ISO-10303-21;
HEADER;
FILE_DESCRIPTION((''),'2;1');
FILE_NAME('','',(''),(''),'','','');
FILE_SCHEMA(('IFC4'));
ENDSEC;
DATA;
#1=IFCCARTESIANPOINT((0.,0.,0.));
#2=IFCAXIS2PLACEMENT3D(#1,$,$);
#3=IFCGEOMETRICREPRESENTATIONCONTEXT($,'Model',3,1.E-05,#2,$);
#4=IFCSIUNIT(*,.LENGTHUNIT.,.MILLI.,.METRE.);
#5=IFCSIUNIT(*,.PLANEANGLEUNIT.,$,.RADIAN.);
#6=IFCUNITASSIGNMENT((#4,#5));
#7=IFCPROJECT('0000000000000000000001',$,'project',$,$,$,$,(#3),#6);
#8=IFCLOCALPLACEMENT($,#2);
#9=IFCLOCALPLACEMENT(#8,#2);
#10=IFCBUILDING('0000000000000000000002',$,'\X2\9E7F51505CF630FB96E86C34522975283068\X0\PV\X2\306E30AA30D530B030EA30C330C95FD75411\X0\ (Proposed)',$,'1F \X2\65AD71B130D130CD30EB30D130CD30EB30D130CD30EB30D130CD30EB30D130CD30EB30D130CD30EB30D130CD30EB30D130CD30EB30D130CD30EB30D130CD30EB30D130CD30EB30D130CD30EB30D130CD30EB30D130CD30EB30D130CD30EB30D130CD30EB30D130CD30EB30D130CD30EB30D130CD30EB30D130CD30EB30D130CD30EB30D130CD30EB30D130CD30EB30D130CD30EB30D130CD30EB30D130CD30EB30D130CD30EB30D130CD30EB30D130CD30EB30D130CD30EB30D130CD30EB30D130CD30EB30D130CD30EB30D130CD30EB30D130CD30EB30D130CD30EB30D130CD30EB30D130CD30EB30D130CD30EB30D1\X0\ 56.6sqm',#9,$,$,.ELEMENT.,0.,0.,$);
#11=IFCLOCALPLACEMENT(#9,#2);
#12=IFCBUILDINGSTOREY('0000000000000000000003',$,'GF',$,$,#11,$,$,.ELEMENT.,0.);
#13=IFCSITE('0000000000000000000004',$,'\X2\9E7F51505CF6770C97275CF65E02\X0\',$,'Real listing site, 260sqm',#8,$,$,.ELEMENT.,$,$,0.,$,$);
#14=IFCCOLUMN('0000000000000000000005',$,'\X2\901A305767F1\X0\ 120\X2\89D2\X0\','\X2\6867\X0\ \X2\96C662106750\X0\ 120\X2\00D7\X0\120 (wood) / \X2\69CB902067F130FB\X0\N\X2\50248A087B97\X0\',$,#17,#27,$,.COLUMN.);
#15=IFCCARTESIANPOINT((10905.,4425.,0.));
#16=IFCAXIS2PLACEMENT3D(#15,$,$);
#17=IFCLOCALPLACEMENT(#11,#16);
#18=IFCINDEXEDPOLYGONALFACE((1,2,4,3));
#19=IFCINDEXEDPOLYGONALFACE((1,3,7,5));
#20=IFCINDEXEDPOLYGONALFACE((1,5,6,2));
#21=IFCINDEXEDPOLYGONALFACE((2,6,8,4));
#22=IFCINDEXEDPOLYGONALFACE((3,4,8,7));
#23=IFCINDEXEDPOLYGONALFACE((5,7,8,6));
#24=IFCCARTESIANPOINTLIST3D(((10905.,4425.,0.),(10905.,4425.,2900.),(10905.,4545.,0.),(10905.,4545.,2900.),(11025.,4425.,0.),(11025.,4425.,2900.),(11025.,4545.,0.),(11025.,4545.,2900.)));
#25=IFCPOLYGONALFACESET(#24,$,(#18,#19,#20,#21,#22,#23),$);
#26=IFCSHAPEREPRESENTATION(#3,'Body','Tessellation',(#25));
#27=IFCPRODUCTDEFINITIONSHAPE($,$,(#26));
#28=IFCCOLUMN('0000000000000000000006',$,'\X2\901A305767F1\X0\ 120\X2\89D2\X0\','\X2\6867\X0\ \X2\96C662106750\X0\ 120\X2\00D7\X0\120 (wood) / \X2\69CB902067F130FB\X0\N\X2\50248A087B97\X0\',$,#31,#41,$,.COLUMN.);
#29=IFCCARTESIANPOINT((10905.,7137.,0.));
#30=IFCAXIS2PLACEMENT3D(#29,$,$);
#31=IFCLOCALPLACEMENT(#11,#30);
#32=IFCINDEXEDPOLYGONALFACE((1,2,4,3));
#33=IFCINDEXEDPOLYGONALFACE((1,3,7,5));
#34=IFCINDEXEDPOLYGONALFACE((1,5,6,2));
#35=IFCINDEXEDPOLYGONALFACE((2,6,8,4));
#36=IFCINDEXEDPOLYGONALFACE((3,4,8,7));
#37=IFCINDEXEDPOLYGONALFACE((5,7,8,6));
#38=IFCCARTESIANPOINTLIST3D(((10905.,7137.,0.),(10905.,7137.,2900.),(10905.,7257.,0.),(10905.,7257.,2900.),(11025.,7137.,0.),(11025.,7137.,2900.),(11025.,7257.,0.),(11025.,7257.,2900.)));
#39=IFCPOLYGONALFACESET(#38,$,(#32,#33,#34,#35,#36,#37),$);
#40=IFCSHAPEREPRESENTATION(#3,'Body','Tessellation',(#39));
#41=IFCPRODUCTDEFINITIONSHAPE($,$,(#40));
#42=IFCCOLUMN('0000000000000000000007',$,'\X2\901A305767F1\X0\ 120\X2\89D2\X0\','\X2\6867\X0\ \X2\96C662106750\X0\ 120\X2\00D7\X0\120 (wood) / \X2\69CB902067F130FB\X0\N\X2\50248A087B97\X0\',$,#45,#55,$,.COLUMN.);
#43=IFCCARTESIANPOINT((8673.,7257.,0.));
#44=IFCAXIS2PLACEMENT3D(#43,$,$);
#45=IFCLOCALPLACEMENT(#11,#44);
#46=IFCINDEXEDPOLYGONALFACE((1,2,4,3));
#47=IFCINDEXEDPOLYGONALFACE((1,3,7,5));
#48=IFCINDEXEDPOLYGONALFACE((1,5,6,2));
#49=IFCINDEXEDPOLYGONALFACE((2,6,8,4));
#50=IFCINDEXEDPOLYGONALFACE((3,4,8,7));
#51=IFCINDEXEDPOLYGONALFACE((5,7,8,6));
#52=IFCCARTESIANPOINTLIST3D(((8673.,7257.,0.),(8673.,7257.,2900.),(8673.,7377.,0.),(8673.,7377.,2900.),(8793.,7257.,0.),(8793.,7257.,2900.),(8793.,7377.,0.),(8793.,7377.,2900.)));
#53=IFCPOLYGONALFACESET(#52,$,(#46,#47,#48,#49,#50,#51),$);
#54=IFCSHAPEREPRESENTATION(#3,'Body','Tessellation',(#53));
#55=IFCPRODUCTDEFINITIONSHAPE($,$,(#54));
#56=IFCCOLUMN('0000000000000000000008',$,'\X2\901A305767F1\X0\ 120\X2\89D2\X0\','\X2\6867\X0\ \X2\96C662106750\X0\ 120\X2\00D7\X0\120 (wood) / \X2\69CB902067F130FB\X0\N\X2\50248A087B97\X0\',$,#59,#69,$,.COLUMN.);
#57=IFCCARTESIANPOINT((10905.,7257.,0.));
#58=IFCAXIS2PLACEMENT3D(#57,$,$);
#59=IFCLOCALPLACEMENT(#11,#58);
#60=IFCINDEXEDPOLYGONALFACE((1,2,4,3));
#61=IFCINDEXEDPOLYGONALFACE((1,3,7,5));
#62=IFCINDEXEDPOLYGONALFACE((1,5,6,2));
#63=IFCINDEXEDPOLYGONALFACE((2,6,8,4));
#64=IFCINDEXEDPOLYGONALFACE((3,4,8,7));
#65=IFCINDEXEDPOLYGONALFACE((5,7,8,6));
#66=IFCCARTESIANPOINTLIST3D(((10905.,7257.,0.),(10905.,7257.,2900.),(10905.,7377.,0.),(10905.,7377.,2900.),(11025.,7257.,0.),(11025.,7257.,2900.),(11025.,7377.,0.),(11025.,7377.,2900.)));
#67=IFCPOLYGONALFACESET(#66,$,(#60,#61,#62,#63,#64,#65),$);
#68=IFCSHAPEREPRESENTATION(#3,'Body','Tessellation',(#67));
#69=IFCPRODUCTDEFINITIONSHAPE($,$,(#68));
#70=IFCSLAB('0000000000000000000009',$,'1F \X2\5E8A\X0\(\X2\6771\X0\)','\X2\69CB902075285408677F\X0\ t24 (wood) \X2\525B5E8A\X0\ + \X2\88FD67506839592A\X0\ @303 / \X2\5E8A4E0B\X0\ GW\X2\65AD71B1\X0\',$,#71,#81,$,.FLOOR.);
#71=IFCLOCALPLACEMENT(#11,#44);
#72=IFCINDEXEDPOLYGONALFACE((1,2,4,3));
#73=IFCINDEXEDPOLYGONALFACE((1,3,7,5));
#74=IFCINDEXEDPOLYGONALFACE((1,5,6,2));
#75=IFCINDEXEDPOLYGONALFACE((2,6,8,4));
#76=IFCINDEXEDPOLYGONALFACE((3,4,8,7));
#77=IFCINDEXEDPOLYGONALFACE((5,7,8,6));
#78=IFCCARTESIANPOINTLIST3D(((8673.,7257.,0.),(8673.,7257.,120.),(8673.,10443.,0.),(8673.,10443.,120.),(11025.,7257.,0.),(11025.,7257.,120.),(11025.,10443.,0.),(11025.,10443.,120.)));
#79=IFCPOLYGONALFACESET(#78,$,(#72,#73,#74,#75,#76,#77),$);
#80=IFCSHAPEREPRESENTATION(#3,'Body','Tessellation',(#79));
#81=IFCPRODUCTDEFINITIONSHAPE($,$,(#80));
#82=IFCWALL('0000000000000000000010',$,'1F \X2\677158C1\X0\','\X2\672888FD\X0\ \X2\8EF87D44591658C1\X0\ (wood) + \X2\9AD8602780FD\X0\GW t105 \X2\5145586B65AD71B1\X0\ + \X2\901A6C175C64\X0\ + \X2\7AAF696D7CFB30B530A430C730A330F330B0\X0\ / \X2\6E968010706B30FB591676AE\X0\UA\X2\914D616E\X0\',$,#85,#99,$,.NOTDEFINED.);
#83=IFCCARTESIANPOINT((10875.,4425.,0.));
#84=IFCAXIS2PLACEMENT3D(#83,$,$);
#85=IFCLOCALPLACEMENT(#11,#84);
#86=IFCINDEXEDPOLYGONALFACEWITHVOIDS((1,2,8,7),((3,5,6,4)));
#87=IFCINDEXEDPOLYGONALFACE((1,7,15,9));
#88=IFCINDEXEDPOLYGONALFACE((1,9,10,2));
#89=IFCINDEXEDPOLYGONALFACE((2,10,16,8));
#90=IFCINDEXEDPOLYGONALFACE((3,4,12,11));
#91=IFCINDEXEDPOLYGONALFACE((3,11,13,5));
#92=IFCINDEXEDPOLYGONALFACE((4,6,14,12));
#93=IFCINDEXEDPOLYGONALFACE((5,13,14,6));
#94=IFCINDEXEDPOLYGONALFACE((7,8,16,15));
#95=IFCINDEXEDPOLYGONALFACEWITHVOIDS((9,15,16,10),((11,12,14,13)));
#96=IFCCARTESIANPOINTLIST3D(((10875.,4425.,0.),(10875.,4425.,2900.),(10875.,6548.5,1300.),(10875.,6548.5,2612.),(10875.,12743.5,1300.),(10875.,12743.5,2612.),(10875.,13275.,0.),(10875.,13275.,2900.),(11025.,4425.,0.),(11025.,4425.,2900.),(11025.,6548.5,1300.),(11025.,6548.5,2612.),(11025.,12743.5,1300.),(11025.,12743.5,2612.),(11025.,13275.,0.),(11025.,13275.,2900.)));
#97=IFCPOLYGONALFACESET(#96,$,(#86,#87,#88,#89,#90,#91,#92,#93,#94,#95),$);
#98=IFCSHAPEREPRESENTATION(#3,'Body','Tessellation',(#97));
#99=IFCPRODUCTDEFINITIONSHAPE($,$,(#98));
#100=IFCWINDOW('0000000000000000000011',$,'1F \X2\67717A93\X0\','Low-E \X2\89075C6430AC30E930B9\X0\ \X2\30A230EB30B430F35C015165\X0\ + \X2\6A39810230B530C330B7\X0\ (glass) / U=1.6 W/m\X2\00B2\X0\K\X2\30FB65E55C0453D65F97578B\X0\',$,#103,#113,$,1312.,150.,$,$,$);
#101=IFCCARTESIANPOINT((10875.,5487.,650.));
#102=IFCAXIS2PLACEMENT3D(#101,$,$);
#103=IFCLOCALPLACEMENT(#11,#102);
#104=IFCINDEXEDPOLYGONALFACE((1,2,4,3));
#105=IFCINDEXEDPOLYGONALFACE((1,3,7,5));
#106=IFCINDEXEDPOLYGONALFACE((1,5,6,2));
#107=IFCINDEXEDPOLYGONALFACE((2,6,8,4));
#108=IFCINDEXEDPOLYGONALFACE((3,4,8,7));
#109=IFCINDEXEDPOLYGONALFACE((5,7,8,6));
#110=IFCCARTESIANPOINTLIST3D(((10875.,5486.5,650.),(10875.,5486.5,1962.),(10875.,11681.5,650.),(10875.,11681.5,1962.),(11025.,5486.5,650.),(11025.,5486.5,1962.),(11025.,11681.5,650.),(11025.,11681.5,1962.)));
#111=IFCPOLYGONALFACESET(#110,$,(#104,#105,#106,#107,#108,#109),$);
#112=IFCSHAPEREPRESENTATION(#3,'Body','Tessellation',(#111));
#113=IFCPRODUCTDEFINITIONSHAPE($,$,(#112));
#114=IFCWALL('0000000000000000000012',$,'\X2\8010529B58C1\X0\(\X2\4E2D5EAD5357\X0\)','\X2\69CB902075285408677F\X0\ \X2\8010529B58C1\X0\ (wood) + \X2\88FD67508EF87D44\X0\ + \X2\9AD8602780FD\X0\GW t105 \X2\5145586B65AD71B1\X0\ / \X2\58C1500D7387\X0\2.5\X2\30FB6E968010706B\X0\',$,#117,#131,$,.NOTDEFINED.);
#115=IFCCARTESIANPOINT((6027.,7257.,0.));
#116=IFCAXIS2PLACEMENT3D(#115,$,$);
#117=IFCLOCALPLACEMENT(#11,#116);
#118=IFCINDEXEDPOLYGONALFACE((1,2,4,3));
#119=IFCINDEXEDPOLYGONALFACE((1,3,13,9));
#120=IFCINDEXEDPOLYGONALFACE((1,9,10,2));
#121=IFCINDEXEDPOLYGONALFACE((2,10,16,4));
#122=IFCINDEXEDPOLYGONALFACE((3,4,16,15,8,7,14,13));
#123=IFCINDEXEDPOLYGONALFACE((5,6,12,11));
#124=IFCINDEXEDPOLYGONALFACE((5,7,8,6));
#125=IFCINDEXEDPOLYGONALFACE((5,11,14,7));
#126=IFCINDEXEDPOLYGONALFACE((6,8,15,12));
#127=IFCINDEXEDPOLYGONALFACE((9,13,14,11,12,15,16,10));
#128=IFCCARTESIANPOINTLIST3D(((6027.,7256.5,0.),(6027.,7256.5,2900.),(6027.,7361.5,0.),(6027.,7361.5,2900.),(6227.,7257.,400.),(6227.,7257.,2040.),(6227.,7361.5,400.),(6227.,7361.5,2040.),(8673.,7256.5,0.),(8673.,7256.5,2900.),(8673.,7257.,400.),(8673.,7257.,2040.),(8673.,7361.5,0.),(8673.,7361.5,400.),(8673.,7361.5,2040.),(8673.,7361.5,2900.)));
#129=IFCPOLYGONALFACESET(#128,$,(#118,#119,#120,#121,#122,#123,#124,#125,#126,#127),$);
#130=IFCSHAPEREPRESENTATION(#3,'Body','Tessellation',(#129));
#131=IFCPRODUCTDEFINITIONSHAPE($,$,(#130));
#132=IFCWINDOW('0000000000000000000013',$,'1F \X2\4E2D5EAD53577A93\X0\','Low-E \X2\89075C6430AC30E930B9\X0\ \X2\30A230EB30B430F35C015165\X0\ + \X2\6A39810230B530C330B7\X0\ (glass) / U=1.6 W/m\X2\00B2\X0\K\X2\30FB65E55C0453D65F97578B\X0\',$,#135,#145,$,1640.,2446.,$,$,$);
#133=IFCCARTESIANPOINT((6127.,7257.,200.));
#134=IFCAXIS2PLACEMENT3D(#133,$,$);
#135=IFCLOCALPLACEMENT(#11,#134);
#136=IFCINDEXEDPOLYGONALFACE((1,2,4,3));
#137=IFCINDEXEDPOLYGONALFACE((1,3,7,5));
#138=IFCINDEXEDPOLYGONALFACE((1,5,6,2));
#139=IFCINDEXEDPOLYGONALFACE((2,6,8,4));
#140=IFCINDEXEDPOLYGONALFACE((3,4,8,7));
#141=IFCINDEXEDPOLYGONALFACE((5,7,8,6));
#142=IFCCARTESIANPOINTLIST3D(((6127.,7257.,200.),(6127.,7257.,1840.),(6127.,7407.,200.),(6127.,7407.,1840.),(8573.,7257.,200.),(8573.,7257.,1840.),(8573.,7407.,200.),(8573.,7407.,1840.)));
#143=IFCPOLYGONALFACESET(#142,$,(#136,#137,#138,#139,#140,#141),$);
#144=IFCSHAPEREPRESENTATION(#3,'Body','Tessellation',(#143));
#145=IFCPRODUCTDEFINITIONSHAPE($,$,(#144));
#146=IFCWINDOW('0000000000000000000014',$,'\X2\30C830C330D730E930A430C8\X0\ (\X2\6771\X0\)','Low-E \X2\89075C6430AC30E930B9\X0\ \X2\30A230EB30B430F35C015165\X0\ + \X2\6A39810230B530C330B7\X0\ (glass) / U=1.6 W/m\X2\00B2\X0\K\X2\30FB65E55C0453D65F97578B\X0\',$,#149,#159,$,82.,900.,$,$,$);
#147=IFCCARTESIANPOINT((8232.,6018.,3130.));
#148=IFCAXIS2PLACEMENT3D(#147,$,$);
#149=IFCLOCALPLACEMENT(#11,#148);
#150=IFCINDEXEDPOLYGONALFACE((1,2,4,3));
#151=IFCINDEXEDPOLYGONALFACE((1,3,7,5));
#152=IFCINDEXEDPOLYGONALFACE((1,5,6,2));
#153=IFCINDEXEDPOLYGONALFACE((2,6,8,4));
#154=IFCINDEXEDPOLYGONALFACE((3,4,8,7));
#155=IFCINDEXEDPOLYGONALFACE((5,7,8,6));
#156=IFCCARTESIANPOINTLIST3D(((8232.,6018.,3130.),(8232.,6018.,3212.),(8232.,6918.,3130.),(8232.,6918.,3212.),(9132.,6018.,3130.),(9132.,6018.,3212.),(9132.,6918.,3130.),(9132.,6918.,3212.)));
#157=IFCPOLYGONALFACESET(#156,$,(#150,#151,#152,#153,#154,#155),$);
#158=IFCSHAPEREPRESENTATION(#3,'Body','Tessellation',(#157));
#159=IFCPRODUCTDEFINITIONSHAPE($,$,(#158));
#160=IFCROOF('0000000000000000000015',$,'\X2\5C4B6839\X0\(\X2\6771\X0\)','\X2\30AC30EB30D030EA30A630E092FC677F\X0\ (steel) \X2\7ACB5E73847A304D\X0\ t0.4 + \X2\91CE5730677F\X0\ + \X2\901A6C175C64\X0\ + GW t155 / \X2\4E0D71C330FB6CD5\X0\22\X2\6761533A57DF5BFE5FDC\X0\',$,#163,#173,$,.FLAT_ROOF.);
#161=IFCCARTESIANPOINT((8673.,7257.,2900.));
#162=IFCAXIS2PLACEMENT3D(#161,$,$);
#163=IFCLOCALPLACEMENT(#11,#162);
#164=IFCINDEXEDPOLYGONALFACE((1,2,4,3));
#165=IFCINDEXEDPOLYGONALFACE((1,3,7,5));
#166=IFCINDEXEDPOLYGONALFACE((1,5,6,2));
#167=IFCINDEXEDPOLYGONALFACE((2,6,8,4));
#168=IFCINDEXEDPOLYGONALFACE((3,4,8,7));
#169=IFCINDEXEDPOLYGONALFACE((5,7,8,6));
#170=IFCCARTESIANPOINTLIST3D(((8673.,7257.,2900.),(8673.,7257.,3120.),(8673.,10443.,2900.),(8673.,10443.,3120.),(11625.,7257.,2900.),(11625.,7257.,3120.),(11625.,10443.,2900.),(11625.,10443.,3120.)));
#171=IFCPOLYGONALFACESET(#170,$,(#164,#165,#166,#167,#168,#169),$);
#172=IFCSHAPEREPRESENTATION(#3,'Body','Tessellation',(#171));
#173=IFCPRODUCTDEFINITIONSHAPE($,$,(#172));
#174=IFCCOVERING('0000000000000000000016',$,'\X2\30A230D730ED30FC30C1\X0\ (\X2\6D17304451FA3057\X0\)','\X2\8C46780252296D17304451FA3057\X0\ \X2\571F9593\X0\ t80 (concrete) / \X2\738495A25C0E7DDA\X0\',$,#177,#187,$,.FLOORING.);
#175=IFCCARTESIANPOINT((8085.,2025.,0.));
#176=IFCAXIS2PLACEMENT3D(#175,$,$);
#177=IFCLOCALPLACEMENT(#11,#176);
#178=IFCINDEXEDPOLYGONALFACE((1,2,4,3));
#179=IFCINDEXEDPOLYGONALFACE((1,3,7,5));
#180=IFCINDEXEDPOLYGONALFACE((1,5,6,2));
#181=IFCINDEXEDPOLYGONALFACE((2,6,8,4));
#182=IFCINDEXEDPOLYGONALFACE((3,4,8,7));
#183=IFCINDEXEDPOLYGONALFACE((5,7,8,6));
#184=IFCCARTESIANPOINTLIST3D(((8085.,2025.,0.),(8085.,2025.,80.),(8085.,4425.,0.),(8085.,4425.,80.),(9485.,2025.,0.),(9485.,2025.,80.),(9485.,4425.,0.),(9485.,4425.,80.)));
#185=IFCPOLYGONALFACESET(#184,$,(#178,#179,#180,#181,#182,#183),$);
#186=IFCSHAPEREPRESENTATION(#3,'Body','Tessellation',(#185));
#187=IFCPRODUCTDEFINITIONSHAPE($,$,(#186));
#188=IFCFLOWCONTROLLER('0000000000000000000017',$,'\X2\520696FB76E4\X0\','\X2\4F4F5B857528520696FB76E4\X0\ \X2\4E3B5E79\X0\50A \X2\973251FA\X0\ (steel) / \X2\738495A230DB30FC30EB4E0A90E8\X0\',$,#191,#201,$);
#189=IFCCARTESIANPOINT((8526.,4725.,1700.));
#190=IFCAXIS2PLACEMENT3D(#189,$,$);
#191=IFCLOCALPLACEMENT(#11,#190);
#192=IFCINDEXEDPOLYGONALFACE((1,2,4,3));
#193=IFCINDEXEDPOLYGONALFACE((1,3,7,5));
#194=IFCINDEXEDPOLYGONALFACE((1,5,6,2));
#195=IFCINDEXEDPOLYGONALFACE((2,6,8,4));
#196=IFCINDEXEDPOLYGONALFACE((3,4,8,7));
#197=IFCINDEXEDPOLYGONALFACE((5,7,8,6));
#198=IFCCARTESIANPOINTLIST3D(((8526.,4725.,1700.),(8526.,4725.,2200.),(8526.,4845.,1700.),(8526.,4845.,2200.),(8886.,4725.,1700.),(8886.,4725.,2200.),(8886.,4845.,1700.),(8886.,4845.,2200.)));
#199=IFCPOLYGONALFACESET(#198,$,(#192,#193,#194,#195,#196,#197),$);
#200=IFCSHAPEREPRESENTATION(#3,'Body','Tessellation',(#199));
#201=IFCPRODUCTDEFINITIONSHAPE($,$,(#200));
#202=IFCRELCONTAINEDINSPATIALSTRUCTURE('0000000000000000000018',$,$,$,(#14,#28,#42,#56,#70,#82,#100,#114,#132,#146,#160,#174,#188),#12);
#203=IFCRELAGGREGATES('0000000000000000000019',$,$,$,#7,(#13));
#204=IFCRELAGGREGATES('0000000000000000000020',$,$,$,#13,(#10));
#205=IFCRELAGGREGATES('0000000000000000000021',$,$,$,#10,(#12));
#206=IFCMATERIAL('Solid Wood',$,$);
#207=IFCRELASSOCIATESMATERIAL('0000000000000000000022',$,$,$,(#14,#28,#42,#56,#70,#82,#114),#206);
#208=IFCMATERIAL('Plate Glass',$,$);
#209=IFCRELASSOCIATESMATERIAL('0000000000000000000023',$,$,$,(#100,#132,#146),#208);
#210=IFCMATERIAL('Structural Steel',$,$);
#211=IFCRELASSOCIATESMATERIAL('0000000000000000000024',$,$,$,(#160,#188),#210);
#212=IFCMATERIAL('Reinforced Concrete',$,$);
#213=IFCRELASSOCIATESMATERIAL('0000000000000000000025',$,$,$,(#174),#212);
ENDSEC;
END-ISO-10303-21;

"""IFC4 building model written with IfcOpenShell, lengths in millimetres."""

from ifc_helpers import new_model, si_unit, frame, frame_2d, origin, place, context, project, spatial, rectangle, extrude, material, element, fill, save


model = new_model("IFC4")

# Units and contexts
model_context = context("Model", 3, precision=1e-05, world=origin())
ifc_project = project(units=[si_unit("LENGTHUNIT", "METRE", prefix="MILLI"), si_unit("PLANEANGLEUNIT", "RADIAN")], contexts=[model_context])

# Site, building, storey
site_placement = place(None, origin())
site = spatial("IfcSite", under=ifc_project, at=site_placement, Name="鹿児島県霧島市", ObjectType="Real listing site, 260sqm", CompositionType="ELEMENT", RefElevation=0.0)
building_placement = place(site_placement, origin())
building = spatial("IfcBuilding", under=site, at=building_placement, Name="鹿児島・雨水利用とPVのオフグリッド志向 (Proposed)", ObjectType="1F 断熱パネルパネルパネルパネルパネルパネルパネルパネルパネルパネルパネルパネルパネルパネルパネルパネルパネルパネルパネルパネルパネルパネルパネルパネルパネルパネルパネルパネルパネルパネルパネルパネルパネルパネルパネルパネルパネルパネルパネルパ 56.6sqm", CompositionType="ELEMENT", ElevationOfRefHeight=0.0, ElevationOfTerrain=0.0)
storey_placement = place(building_placement, origin())
storey = spatial("IfcBuildingStorey", under=building, at=storey_placement, Name="GF", CompositionType="ELEMENT", Elevation=0.0)

# Columns
ifc_material_1 = material(Name="Solid Wood")
column_1_placement = place(storey_placement, frame((10905.0, 4425.0, 0.0)))
element("IfcColumn", 1, at=column_1_placement, inside=storey, material=ifc_material_1, Name="通し柱 120角", Description="桧 集成材 120×120 (wood) / 構造柱・N値計算", PredefinedType="COLUMN", context=model_context, shape_type="SweptSolid", body=[
    extrude(rectangle(XDim=120.0, YDim=120.0, at=frame_2d((60.0, 60.0))), frame((10905.0, 4425.0, 0.0)), (0.0, 0.0, 1.0), 2900.0),
])
column_2_placement = place(storey_placement, frame((10905.0, 7137.0, 0.0)))
element("IfcColumn", 2, at=column_2_placement, inside=storey, material=ifc_material_1, Name="通し柱 120角", Description="桧 集成材 120×120 (wood) / 構造柱・N値計算", PredefinedType="COLUMN", context=model_context, shape_type="SweptSolid", body=[
    extrude(rectangle(XDim=120.0, YDim=120.0, at=frame_2d((60.0, 60.0))), frame((10905.0, 7137.0, 0.0)), (0.0, 0.0, 1.0), 2900.0),
])
column_3_placement = place(storey_placement, frame((8673.0, 7257.0, 0.0)))
element("IfcColumn", 3, at=column_3_placement, inside=storey, material=ifc_material_1, Name="通し柱 120角", Description="桧 集成材 120×120 (wood) / 構造柱・N値計算", PredefinedType="COLUMN", context=model_context, shape_type="SweptSolid", body=[
    extrude(rectangle(XDim=120.0, YDim=120.0, at=frame_2d((60.0, 60.0))), frame((8673.0, 7257.0, 0.0)), (0.0, 0.0, 1.0), 2900.0),
])
column_4_placement = place(storey_placement, frame((10905.0, 7257.0, 0.0)))
element("IfcColumn", 4, at=column_4_placement, inside=storey, material=ifc_material_1, Name="通し柱 120角", Description="桧 集成材 120×120 (wood) / 構造柱・N値計算", PredefinedType="COLUMN", context=model_context, shape_type="SweptSolid", body=[
    extrude(rectangle(XDim=120.0, YDim=120.0, at=frame_2d((60.0, 60.0))), frame((10905.0, 7257.0, 0.0)), (0.0, 0.0, 1.0), 2900.0),
])

# Slab
slab_placement = place(storey_placement, frame((8673.0, 7257.0, 0.0)))
element("IfcSlab", 5, at=slab_placement, inside=storey, material=ifc_material_1, Name="1F 床(東)", Description="構造用合板 t24 (wood) 剛床 + 製材根太 @303 / 床下 GW断熱", PredefinedType="FLOOR", context=model_context, shape_type="SweptSolid", body=[
    extrude(rectangle(XDim=2352.0, YDim=3186.0, at=frame_2d((1176.0, 1593.0))), frame((8673.0, 7257.0, 0.0)), (0.0, 0.0, 1.0), 120.0),
])

# Walls, openings, windows
wall_1_placement = place(storey_placement, frame((10875.0, 4425.0, 0.0)))
wall_1 = element("IfcWall", 6, at=wall_1_placement, inside=storey, material=ifc_material_1, Name="1F 東壁", Description="木製 軸組外壁 (wood) + 高性能GW t105 充填断熱 + 通気層 + 窯業系サイディング / 準耐火・外皮UA配慮", PredefinedType="NOTDEFINED", context=model_context, shape_type="SweptSolid", body=[
    extrude(rectangle(XDim=150.0, YDim=8850.0, at=frame_2d((75.0, 4425.0))), frame((10875.0, 4425.0, 0.0)), (0.0, 0.0, 1.0), 2900.0),
])
opening_1_placement = place(storey_placement, frame((10875.0, 5487.0, 650.0)))
opening_1 = element("IfcOpeningElement", 7, at=opening_1_placement, cuts=wall_1, PredefinedType="NOTDEFINED", context=model_context, shape_type="SweptSolid", body=[
    extrude(rectangle(XDim=150.0, YDim=6195.0, at=frame_2d((75.0, 3097.0))), frame((10875.0, 5487.0, 650.0)), (0.0, 0.0, 1.0), 1312.0),
])
ifc_material_2 = material(Name="Plate Glass")
window_1_placement = place(storey_placement, frame((10875.0, 5487.0, 650.0)))
window_1 = element("IfcWindow", 8, at=window_1_placement, inside=storey, material=ifc_material_2, Name="1F 東窓", Description="Low-E 複層ガラス アルゴン封入 + 樹脂サッシ (glass) / U=1.6 W/m²K・日射取得型", OverallHeight=1312.0, OverallWidth=150.0, context=model_context, shape_type="SweptSolid", body=[
    extrude(rectangle(XDim=150.0, YDim=6195.0, at=frame_2d((75.0, 3097.0))), frame((10875.0, 5487.0, 650.0)), (0.0, 0.0, 1.0), 1312.0),
])
fill(opening_1, window_1)
wall_2_placement = place(storey_placement, frame((6027.0, 7257.0, 0.0)))
wall_2 = element("IfcWall", 9, at=wall_2_placement, inside=storey, material=ifc_material_1, Name="耐力壁(中庭南)", Description="構造用合板 耐力壁 (wood) + 製材軸組 + 高性能GW t105 充填断熱 / 壁倍率2.5・準耐火", PredefinedType="NOTDEFINED", context=model_context, shape_type="SweptSolid", body=[
    extrude(rectangle(XDim=2646.0, YDim=105.0, at=frame_2d((1323.0, 52.0))), frame((6027.0, 7257.0, 0.0)), (0.0, 0.0, 1.0), 2900.0),
])
opening_2_placement = place(storey_placement, frame((6127.0, 7257.0, 200.0)))
opening_2 = element("IfcOpeningElement", 10, at=opening_2_placement, cuts=wall_2, PredefinedType="NOTDEFINED", context=model_context, shape_type="SweptSolid", body=[
    extrude(rectangle(XDim=2446.0, YDim=150.0, at=frame_2d((1223.0, 75.0))), frame((6127.0, 7257.0, 200.0)), (0.0, 0.0, 1.0), 1640.0),
])
window_2_placement = place(storey_placement, frame((6127.0, 7257.0, 200.0)))
window_2 = element("IfcWindow", 11, at=window_2_placement, inside=storey, material=ifc_material_2, Name="1F 中庭南窓", Description="Low-E 複層ガラス アルゴン封入 + 樹脂サッシ (glass) / U=1.6 W/m²K・日射取得型", OverallHeight=1640.0, OverallWidth=2446.0, context=model_context, shape_type="SweptSolid", body=[
    extrude(rectangle(XDim=2446.0, YDim=150.0, at=frame_2d((1223.0, 75.0))), frame((6127.0, 7257.0, 200.0)), (0.0, 0.0, 1.0), 1640.0),
])
fill(opening_2, window_2)

# Window
window_3_placement = place(storey_placement, frame((8232.0, 6018.0, 3130.0)))
element("IfcWindow", 12, at=window_3_placement, inside=storey, material=ifc_material_2, Name="トップライト (東)", Description="Low-E 複層ガラス アルゴン封入 + 樹脂サッシ (glass) / U=1.6 W/m²K・日射取得型", OverallHeight=82.0, OverallWidth=900.0, context=model_context, shape_type="SweptSolid", body=[
    extrude(rectangle(XDim=900.0, YDim=900.0, at=frame_2d((450.0, 450.0))), frame((8232.0, 6018.0, 3130.0)), (0.0, 0.0, 1.0), 82.0),
])

# Roof
ifc_material_3 = material(Name="Structural Steel")
roof_placement = place(storey_placement, frame((8673.0, 7257.0, 2900.0)))
element("IfcRoof", 13, at=roof_placement, inside=storey, material=ifc_material_3, Name="屋根(東)", Description="ガルバリウム鋼板 (steel) 立平葺き t0.4 + 野地板 + 通気層 + GW t155 / 不燃・法22条区域対応", PredefinedType="FLAT_ROOF", context=model_context, shape_type="SweptSolid", body=[
    extrude(rectangle(XDim=2952.0, YDim=3186.0, at=frame_2d((1476.0, 1593.0))), frame((8673.0, 7257.0, 2900.0)), (0.0, 0.0, 1.0), 220.0),
])

# Covering
ifc_material_4 = material(Name="Reinforced Concrete")
covering_placement = place(storey_placement, frame((8085.0, 2025.0, 0.0)))
element("IfcCovering", 14, at=covering_placement, inside=storey, material=ifc_material_4, Name="アプローチ (洗い出し)", Description="豆砂利洗い出し 土間 t80 (concrete) / 玄関導線", PredefinedType="FLOORING", context=model_context, shape_type="SweptSolid", body=[
    extrude(rectangle(XDim=1400.0, YDim=2400.0, at=frame_2d((700.0, 1200.0))), frame((8085.0, 2025.0, 0.0)), (0.0, 0.0, 1.0), 80.0),
])

# Flow controller
flow_controller_placement = place(storey_placement, frame((8526.0, 4725.0, 1700.0)))
element("IfcFlowController", 15, at=flow_controller_placement, inside=storey, material=ifc_material_3, Name="分電盤", Description="住宅用分電盤 主幹50A 露出 (steel) / 玄関ホール上部", context=model_context, shape_type="SweptSolid", body=[
    extrude(rectangle(XDim=360.0, YDim=120.0, at=frame_2d((180.0, 60.0))), frame((8526.0, 4725.0, 1700.0)), (0.0, 0.0, 1.0), 500.0),
])

save(model, "model.ifc")
